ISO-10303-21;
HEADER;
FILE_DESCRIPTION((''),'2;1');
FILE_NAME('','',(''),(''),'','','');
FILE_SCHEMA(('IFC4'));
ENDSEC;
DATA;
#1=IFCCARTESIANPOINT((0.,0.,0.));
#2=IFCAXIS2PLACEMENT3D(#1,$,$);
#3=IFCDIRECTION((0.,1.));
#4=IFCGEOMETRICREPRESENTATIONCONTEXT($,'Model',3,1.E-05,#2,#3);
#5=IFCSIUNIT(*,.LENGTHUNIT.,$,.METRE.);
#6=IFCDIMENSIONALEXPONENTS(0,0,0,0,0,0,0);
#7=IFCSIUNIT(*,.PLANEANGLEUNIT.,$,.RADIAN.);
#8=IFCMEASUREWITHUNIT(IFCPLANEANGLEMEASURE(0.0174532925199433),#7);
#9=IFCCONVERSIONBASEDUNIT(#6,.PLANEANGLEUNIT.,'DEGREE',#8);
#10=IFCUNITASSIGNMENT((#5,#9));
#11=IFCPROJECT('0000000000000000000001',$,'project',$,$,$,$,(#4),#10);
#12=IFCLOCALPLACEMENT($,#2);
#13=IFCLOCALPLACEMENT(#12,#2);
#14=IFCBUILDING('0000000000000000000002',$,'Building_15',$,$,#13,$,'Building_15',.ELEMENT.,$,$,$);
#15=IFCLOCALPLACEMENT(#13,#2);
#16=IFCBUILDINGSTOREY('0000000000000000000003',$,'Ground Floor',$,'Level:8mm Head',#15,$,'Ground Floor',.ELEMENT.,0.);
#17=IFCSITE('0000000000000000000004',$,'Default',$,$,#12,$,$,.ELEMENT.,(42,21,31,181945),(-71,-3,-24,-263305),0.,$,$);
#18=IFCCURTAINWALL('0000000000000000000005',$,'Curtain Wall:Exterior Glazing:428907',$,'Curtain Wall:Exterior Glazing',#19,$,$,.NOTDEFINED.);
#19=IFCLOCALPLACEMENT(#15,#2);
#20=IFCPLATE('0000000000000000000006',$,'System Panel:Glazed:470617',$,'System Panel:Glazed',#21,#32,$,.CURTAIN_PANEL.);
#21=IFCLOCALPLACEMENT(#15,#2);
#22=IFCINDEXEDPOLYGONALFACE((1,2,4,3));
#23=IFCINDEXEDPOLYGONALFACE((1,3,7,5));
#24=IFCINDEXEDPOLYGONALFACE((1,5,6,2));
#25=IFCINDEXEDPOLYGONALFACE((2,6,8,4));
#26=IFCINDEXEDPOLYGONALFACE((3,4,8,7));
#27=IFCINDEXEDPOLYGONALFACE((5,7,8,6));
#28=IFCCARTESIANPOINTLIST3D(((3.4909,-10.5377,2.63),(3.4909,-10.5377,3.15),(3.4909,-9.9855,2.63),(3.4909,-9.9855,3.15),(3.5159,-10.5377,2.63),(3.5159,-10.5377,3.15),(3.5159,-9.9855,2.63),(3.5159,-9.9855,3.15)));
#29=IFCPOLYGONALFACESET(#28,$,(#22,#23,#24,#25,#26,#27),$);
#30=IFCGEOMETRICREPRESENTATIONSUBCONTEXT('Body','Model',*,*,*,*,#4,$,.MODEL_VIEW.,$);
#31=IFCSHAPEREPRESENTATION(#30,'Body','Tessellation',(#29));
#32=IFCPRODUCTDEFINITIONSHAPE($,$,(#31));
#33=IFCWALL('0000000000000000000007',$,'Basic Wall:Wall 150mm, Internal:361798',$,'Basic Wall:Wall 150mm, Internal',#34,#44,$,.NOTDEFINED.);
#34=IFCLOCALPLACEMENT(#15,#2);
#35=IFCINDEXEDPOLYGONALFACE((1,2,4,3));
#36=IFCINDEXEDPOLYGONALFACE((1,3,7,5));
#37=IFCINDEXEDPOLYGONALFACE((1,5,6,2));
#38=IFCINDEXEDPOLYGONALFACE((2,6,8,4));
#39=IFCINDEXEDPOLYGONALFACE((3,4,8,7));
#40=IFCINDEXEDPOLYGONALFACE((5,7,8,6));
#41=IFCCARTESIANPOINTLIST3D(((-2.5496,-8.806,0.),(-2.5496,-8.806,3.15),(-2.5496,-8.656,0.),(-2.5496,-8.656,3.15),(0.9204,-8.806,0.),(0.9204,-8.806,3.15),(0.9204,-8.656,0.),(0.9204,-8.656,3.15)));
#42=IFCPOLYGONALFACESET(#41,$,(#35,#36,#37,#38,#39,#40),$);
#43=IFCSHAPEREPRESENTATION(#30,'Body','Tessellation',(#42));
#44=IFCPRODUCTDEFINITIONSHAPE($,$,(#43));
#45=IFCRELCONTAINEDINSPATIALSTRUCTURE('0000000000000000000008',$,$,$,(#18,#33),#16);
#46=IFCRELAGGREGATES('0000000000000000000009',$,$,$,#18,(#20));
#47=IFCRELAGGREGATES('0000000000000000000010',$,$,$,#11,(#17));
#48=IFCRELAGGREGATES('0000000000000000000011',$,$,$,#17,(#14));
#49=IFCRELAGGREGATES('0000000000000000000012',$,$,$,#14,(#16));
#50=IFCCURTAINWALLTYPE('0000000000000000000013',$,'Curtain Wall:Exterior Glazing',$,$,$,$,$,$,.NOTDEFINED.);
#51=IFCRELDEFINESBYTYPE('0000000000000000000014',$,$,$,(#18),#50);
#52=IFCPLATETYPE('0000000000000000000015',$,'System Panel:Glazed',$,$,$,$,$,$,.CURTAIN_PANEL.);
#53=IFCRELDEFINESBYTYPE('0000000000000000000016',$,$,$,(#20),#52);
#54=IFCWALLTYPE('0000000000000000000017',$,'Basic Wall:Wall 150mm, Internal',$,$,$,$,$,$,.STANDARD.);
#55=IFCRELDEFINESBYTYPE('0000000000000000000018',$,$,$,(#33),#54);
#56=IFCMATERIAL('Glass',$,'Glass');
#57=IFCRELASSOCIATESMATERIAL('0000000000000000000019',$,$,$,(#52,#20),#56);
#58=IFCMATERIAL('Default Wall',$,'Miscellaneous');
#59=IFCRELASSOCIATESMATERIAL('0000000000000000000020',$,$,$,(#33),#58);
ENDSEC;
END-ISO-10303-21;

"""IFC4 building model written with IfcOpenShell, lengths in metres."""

from ifc_helpers import new_model, entity, si_unit, converted_unit, direction, frame, origin, place, context, subcontext, project, spatial, indexed_curve, outline, extrude, source, transform, mapped, material, type_object, type_shapes, element, aggregate, save


model = new_model("IFC4")

# Units and contexts
model_context = context("Model", 3, precision=1e-05, world=origin(), true_north=direction((0.0, 1.0)))
body_context = subcontext(model_context, "Body", "Model", "MODEL_VIEW")
ifc_project = project(units=[si_unit("LENGTHUNIT", "METRE"), converted_unit("PLANEANGLEUNIT", "DEGREE", entity("IfcPlaneAngleMeasure", 0.0174532925199433), si_unit("PLANEANGLEUNIT", "RADIAN"), dimensions=[0, 0, 0, 0, 0, 0, 0])], contexts=[model_context])

# Site, building, storey
site_placement = place(None, origin())
site = spatial("IfcSite", under=ifc_project, at=site_placement, Name="Default", CompositionType="ELEMENT", RefLatitude=(42, 21, 31, 181945), RefLongitude=(-71, -3, -24, -263305), RefElevation=0.0)
building_placement = place(site_placement, origin())
building = spatial("IfcBuilding", under=site, at=building_placement, Name="Building_15", LongName="Building_15", CompositionType="ELEMENT")
storey_placement = place(building_placement, origin())
storey = spatial("IfcBuildingStorey", under=building, at=storey_placement, Name="Ground Floor", ObjectType="Level:8mm Head", LongName="Ground Floor", CompositionType="ELEMENT", Elevation=0.0)

# Curtain wall, plate
curtain_wall_type = type_object("IfcCurtainWallType", Name="Curtain Wall:Exterior Glazing", PredefinedType="NOTDEFINED")
curtain_wall_placement = place(storey_placement, origin())
curtain_wall = element("IfcCurtainWall", 1, at=curtain_wall_placement, inside=storey, type_object=curtain_wall_type, Name="Curtain Wall:Exterior Glazing:428907", ObjectType="Curtain Wall:Exterior Glazing", PredefinedType="NOTDEFINED")
ifc_material_1 = material(Name="Glass", Category="Glass")
plate_type_1 = type_object("IfcPlateType", Name="System Panel:Glazed", PredefinedType="CURTAIN_PANEL", material=ifc_material_1)
shared_shape_1 = source(origin(), body_context, "Body", "SweptSolid", [
    extrude(outline(indexed_curve([(-0.0125, -0.2761), (0.0125, -0.2761), (0.0125, 0.2761), (-0.0125, 0.2761), (-0.0125, -0.2761)], self_intersect=False)), frame((0.0, 0.037, 0.0), z_axis=(0.0, 0.0, 1.0), x_axis=(0.0, 1.0, 0.0)), (0.0, 0.0, 1.0), 0.52),
])
type_shapes(plate_type_1, [shared_shape_1])
plate_1_placement = place(curtain_wall_placement, frame((3.5404, -10.2616, 2.63), z_axis=(0.0, 0.0, 1.0), x_axis=(0.0, 1.0, 0.0)))
plate_1 = element("IfcPlate", 2, at=plate_1_placement, type_object=plate_type_1, material=ifc_material_1, Name="System Panel:Glazed:470617", ObjectType="System Panel:Glazed", PredefinedType="CURTAIN_PANEL", context=body_context, shape_type="MappedRepresentation", body=[
    mapped(shared_shape_1, transform((0.0, 0.0, 0.0), scale=1.0)),
])
aggregate(curtain_wall, [plate_1])

# Wall
ifc_material_2 = material(Name="Default Wall", Category="Miscellaneous")
wall_type = type_object("IfcWallType", Name="Basic Wall:Wall 150mm, Internal", PredefinedType="STANDARD")
wall_placement = place(storey_placement, frame((0.9204, -8.731, 0.0), z_axis=(0.0, 0.0, 1.0), x_axis=(-1.0, 0.0, 0.0)))
element("IfcWall", 3, at=wall_placement, inside=storey, type_object=wall_type, material=ifc_material_2, Name="Basic Wall:Wall 150mm, Internal:361798", ObjectType="Basic Wall:Wall 150mm, Internal", PredefinedType="NOTDEFINED", context=body_context, shape_type="SweptSolid", body=[
    extrude(outline(indexed_curve([(3.47, 0.075), (0.0, 0.075), (0.0, -0.075), (3.47, -0.075), (3.47, 0.075)], self_intersect=False)), origin(), (0.0, 0.0, 1.0), 3.15),
])

save(model, "model.ifc")
